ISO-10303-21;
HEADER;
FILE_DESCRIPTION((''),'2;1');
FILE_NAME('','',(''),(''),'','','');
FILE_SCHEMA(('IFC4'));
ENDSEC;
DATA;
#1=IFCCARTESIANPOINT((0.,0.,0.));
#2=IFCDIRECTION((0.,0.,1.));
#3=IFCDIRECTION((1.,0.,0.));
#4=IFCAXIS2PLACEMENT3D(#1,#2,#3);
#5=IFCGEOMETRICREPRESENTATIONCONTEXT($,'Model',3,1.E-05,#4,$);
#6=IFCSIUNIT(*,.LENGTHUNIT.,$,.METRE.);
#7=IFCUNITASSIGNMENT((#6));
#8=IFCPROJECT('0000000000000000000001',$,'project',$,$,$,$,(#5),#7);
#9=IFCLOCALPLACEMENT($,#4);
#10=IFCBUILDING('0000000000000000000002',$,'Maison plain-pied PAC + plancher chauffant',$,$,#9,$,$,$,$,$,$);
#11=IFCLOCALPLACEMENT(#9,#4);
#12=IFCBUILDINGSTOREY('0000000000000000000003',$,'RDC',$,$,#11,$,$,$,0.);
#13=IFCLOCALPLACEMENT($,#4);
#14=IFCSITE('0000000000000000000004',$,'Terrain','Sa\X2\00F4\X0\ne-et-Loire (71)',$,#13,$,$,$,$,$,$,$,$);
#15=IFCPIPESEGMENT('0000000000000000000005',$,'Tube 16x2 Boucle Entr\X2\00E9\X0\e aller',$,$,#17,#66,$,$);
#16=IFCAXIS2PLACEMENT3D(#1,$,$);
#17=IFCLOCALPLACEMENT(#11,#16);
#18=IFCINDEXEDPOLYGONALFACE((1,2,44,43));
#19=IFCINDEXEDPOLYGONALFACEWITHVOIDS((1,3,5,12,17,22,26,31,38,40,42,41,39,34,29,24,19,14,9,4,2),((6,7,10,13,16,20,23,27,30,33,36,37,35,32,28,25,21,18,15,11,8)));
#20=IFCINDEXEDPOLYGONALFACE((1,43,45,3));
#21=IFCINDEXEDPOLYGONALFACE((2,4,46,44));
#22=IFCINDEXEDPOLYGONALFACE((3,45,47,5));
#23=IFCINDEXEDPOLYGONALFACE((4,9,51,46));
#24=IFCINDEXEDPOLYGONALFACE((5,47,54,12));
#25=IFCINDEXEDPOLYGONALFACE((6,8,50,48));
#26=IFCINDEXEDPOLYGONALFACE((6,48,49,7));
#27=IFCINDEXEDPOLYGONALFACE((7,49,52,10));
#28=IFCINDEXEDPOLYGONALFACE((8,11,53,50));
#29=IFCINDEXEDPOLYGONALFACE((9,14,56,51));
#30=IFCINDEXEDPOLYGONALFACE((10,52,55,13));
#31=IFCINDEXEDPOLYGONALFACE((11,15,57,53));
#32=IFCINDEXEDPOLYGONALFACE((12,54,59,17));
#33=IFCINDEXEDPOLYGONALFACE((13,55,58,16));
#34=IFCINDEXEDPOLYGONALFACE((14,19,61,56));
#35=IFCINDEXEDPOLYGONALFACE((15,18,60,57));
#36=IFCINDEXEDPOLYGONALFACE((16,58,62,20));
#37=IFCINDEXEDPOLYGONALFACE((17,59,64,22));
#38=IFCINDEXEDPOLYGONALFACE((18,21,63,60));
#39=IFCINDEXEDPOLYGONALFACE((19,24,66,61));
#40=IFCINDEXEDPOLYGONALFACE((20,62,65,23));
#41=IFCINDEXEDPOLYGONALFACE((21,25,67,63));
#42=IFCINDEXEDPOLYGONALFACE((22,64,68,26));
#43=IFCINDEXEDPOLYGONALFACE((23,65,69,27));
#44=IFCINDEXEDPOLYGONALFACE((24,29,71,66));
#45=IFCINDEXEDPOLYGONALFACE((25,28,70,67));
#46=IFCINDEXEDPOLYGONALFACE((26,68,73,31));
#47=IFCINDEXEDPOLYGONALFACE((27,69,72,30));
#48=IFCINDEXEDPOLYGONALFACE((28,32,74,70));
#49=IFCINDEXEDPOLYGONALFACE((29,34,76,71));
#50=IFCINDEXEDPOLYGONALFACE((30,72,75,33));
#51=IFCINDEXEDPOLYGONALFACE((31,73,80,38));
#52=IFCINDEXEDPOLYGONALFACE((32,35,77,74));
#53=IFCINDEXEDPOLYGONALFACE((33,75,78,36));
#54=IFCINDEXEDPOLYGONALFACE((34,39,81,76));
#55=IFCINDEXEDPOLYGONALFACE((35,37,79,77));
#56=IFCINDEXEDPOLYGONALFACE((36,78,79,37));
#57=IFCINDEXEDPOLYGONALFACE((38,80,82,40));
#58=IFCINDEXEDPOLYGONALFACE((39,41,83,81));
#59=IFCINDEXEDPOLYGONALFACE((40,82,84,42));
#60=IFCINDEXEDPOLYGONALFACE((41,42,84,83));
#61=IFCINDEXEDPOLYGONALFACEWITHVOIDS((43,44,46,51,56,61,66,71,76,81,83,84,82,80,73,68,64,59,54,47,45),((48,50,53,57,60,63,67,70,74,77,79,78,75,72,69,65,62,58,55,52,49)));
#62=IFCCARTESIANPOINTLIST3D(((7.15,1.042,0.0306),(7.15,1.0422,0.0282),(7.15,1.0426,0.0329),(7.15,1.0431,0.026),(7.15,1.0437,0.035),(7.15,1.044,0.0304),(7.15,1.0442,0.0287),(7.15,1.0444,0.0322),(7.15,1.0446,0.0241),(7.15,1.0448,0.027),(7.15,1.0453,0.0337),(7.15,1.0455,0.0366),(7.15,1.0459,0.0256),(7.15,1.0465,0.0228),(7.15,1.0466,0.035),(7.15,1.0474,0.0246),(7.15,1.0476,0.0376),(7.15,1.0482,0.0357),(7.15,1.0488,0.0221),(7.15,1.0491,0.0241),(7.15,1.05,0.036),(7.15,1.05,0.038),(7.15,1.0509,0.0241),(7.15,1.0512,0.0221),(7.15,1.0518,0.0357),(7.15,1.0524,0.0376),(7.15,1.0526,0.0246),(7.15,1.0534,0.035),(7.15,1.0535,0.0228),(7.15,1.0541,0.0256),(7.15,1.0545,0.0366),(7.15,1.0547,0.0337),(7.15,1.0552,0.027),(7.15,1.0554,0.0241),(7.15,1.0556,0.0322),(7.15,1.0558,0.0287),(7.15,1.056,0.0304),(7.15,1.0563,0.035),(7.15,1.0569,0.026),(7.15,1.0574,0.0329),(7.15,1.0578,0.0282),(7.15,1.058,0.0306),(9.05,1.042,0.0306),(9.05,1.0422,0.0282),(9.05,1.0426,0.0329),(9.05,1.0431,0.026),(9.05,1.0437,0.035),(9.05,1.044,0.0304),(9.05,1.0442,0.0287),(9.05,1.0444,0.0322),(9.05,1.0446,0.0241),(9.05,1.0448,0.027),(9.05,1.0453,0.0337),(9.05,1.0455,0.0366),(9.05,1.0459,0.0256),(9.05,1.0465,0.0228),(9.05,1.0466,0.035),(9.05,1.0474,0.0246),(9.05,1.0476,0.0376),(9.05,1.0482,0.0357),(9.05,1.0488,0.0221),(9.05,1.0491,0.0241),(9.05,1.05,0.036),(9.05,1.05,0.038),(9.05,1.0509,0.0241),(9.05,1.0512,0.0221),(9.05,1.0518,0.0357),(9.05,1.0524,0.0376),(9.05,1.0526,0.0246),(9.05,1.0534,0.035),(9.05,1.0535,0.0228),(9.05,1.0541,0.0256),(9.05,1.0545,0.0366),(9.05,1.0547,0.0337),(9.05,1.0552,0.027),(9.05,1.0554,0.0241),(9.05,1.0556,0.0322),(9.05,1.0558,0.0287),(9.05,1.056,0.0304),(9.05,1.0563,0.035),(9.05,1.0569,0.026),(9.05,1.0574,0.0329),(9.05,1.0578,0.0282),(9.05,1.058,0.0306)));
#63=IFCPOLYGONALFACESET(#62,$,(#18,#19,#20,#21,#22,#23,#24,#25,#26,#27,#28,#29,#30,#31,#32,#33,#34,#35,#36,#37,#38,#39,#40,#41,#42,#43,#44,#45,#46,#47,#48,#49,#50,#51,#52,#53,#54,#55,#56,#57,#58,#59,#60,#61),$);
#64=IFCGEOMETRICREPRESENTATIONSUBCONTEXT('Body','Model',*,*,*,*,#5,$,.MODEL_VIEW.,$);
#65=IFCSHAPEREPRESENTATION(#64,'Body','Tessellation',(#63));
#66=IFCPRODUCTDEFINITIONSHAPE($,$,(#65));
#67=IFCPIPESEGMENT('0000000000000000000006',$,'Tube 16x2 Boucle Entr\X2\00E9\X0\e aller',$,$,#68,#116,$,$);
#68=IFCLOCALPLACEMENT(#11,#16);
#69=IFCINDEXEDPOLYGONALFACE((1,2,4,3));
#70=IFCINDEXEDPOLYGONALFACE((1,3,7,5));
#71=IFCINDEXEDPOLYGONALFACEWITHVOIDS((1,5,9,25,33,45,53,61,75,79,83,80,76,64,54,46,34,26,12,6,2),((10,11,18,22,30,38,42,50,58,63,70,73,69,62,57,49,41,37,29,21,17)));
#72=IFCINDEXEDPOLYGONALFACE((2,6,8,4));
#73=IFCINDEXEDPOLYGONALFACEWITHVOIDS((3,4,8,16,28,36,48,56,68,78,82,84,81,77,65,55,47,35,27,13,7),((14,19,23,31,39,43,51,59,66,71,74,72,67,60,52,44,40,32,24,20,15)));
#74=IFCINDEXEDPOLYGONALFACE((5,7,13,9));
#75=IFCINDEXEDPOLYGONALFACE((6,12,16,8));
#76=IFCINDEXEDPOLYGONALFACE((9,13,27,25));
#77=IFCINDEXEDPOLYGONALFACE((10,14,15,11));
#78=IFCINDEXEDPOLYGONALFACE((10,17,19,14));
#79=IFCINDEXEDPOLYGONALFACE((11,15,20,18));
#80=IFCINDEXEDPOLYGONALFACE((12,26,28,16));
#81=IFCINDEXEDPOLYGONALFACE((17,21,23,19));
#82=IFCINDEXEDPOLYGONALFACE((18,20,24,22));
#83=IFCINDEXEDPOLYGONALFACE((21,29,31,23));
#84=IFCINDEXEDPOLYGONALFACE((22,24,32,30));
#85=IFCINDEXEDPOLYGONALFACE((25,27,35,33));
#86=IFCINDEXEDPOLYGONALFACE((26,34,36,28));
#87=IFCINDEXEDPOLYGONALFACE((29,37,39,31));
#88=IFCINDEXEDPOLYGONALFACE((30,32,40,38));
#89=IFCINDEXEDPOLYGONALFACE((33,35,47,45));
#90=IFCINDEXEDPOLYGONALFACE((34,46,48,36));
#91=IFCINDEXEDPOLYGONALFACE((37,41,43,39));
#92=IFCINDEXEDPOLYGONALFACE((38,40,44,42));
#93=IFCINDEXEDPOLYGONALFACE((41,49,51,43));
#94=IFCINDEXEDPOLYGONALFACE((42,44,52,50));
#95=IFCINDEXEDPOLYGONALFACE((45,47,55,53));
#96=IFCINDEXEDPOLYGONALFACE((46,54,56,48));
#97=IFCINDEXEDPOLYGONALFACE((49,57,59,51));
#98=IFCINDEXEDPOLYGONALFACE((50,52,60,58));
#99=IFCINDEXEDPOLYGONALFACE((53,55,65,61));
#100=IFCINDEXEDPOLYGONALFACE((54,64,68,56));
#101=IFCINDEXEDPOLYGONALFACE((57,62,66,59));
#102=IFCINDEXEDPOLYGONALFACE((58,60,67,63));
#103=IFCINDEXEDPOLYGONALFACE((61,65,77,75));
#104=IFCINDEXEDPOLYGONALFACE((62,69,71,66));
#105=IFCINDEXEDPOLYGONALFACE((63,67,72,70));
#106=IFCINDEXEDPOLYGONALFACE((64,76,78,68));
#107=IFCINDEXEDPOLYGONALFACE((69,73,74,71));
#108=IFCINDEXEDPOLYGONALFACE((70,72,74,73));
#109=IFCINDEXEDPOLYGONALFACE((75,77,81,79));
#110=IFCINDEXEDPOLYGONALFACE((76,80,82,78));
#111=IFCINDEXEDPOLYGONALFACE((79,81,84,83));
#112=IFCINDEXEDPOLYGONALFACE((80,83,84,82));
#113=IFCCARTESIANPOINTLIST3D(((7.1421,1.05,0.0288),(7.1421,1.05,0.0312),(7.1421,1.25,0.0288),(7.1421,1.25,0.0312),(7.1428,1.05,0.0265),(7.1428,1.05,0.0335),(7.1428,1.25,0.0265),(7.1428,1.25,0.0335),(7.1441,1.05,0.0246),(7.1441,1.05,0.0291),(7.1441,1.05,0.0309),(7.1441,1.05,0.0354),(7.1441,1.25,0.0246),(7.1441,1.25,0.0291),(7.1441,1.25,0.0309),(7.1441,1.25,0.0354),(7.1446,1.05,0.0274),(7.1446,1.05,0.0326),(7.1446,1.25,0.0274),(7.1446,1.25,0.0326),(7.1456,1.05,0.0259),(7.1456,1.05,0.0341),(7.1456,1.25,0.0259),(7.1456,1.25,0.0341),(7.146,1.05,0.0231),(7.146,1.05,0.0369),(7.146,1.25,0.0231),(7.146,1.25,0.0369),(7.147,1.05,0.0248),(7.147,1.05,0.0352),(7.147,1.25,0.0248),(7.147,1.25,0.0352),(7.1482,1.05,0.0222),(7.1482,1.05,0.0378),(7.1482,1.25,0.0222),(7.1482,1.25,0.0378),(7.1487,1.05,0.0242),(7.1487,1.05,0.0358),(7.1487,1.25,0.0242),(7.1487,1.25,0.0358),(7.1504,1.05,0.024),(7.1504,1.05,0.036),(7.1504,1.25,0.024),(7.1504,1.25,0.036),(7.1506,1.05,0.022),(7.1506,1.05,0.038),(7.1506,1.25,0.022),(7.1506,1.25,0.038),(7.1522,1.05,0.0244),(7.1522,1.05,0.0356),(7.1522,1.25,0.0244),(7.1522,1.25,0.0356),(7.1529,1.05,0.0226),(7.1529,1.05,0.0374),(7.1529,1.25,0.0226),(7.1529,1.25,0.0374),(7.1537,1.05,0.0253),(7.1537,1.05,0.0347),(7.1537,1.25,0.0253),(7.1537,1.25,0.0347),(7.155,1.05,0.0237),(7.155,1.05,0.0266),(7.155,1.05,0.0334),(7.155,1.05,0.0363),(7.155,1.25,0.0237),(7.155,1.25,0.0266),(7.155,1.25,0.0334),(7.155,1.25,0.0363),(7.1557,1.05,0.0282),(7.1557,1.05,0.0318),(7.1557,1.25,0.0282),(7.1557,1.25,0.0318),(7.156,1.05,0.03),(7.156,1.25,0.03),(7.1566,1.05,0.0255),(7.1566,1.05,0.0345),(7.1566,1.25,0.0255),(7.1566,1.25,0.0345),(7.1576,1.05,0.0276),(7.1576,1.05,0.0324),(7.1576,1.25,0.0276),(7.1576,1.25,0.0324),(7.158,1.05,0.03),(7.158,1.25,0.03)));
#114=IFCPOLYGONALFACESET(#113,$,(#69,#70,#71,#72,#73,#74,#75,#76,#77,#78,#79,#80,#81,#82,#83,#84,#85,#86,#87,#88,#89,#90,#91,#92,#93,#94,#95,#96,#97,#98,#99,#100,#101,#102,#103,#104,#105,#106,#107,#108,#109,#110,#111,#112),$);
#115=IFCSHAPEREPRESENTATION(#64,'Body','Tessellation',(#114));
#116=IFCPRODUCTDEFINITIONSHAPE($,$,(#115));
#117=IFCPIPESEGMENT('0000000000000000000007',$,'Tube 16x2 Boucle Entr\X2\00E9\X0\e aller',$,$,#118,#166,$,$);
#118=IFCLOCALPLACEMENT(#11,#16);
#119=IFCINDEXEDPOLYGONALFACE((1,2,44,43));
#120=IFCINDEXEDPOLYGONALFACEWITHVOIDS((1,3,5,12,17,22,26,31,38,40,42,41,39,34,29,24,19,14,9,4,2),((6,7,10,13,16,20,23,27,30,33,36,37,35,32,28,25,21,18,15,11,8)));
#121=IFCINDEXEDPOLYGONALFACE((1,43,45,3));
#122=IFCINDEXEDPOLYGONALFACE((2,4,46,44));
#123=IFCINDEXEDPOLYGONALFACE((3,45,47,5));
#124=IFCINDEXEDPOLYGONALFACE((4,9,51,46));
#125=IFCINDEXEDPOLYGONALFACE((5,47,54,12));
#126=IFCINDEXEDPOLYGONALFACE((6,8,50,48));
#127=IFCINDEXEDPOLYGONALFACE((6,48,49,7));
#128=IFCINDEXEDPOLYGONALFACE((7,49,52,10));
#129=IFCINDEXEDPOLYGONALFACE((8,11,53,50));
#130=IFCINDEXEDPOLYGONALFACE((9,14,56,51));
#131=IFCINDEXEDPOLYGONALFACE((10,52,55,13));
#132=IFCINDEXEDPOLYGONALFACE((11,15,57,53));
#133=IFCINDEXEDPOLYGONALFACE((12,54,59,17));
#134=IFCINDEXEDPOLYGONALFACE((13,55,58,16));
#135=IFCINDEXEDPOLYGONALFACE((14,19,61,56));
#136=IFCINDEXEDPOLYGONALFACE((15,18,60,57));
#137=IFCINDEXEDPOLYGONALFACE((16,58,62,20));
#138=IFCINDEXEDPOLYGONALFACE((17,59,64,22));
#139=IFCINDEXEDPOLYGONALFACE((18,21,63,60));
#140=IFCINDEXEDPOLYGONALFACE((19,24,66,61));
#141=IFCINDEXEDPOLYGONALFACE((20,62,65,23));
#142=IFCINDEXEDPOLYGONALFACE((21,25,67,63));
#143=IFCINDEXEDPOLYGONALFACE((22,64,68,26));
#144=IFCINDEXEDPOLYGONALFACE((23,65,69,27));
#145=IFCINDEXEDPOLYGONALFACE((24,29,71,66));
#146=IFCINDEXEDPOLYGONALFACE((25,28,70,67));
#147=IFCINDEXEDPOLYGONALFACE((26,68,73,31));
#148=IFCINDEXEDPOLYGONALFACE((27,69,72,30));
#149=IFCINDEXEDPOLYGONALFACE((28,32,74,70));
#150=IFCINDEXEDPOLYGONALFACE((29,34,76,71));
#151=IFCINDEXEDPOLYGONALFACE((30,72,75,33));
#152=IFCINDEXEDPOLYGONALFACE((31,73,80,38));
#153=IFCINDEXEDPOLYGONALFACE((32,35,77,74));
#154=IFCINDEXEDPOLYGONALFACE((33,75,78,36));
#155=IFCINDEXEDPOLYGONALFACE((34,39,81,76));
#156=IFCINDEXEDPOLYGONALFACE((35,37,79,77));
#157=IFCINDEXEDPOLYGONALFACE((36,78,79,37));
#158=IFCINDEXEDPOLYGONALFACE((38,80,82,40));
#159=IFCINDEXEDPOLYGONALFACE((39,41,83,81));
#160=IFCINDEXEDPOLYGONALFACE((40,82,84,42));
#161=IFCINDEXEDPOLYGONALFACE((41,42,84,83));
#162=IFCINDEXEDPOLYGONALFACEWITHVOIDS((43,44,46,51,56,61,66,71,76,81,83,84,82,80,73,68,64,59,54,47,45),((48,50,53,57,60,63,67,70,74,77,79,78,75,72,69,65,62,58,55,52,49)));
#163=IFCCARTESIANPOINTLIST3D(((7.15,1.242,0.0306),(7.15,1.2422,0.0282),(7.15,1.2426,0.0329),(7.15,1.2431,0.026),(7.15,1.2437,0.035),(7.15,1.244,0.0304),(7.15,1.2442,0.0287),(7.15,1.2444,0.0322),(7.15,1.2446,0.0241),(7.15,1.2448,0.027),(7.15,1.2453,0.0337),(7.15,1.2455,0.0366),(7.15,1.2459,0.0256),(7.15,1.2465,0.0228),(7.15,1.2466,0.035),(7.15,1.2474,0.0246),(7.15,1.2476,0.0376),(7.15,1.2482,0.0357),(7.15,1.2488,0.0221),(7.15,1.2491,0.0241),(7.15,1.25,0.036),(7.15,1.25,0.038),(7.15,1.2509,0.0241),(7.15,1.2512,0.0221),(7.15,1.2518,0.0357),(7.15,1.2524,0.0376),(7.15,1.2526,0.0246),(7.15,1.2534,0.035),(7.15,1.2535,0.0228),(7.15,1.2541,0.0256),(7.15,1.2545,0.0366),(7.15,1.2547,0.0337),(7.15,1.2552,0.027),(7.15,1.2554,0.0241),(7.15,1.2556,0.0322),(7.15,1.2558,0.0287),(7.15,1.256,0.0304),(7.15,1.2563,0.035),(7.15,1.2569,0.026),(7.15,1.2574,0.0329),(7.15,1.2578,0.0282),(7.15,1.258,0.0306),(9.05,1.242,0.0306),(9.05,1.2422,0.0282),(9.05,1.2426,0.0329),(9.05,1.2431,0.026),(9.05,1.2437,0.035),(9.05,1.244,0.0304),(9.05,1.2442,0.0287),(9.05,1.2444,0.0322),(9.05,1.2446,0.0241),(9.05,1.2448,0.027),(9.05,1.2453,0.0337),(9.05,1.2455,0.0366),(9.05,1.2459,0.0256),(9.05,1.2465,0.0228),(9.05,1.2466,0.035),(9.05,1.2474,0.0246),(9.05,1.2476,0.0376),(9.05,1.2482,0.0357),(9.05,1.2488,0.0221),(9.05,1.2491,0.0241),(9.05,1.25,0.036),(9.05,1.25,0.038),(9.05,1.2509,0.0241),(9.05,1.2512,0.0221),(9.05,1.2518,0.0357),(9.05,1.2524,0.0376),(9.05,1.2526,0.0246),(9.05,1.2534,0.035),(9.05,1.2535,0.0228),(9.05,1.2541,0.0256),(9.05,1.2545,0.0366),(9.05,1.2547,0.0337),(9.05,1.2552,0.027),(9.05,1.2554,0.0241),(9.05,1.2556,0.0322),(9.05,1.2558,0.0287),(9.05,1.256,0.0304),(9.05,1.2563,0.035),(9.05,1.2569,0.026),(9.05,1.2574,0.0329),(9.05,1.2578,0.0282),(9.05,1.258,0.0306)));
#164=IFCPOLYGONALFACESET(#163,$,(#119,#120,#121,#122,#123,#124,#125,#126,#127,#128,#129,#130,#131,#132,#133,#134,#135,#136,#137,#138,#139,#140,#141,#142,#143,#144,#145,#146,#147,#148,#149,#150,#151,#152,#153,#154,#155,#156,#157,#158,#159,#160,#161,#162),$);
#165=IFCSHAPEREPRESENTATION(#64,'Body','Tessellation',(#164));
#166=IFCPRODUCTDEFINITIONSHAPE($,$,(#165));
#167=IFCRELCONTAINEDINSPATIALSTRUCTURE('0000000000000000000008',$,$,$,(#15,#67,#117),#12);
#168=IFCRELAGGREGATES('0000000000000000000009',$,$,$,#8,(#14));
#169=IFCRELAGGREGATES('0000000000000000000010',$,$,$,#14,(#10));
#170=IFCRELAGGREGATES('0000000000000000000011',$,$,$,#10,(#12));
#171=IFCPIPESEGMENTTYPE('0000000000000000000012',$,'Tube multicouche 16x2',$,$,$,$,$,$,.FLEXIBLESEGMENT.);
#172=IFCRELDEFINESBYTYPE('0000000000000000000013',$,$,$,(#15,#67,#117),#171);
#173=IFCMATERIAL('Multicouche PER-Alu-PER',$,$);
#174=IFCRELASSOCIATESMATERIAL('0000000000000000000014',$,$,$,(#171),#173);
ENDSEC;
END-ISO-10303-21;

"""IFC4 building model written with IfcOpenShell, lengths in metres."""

from ifc_helpers import new_model, si_unit, frame, origin_with_axes, place, context, subcontext, project, spatial, hollow_circle, extrude, material, type_object, element, save


model = new_model("IFC4")

# Units and contexts
model_context = context("Model", 3, precision=1e-05, world=origin_with_axes())
body_context = subcontext(model_context, "Body", "Model", "MODEL_VIEW")
ifc_project = project(units=[si_unit("LENGTHUNIT", "METRE")], contexts=[model_context])

# Site, building, storey
site_placement = place(None, origin_with_axes())
site = spatial("IfcSite", under=ifc_project, at=site_placement, Name="Terrain", Description="Saône-et-Loire (71)")
building_placement = place(None, origin_with_axes())
building = spatial("IfcBuilding", under=site, at=building_placement, Name="Maison plain-pied PAC + plancher chauffant")
storey_placement = place(building_placement, origin_with_axes())
storey = spatial("IfcBuildingStorey", under=building, at=storey_placement, Name="RDC", Elevation=0.0)

# Pipe segments
ifc_material_1 = material(Name="Multicouche PER-Alu-PER")
pipe_segment_type = type_object("IfcPipeSegmentType", Name="Tube multicouche 16x2", PredefinedType="FLEXIBLESEGMENT", material=ifc_material_1)
pipe_segment_1_placement = place(storey_placement, frame((9.05, 1.05, 0.03), z_axis=(-1.0, 0.0, 0.0), x_axis=(0.0, 0.0, 1.0)))
element("IfcPipeSegment", 1, at=pipe_segment_1_placement, inside=storey, type_object=pipe_segment_type, Name="Tube 16x2 Boucle Entrée aller", context=body_context, shape_type="SweptSolid", body=[
    extrude(hollow_circle(Radius=0.008, WallThickness=0.002), origin_with_axes(), (0.0, 0.0, 1.0), 1.9),
])
pipe_segment_2_placement = place(storey_placement, frame((7.15, 1.05, 0.03), z_axis=(0.0, 1.0, 0.0), x_axis=(1.0, 0.0, 0.0)))
element("IfcPipeSegment", 2, at=pipe_segment_2_placement, inside=storey, type_object=pipe_segment_type, Name="Tube 16x2 Boucle Entrée aller", context=body_context, shape_type="SweptSolid", body=[
    extrude(hollow_circle(Radius=0.008, WallThickness=0.002), origin_with_axes(), (0.0, 0.0, 1.0), 0.2),
])
pipe_segment_3_placement = place(storey_placement, frame((7.15, 1.25, 0.03), z_axis=(1.0, 0.0, 0.0), x_axis=(0.0, 0.0, 1.0)))
element("IfcPipeSegment", 3, at=pipe_segment_3_placement, inside=storey, type_object=pipe_segment_type, Name="Tube 16x2 Boucle Entrée aller", context=body_context, shape_type="SweptSolid", body=[
    extrude(hollow_circle(Radius=0.008, WallThickness=0.002), origin_with_axes(), (0.0, 0.0, 1.0), 1.9),
])

save(model, "model.ifc")
